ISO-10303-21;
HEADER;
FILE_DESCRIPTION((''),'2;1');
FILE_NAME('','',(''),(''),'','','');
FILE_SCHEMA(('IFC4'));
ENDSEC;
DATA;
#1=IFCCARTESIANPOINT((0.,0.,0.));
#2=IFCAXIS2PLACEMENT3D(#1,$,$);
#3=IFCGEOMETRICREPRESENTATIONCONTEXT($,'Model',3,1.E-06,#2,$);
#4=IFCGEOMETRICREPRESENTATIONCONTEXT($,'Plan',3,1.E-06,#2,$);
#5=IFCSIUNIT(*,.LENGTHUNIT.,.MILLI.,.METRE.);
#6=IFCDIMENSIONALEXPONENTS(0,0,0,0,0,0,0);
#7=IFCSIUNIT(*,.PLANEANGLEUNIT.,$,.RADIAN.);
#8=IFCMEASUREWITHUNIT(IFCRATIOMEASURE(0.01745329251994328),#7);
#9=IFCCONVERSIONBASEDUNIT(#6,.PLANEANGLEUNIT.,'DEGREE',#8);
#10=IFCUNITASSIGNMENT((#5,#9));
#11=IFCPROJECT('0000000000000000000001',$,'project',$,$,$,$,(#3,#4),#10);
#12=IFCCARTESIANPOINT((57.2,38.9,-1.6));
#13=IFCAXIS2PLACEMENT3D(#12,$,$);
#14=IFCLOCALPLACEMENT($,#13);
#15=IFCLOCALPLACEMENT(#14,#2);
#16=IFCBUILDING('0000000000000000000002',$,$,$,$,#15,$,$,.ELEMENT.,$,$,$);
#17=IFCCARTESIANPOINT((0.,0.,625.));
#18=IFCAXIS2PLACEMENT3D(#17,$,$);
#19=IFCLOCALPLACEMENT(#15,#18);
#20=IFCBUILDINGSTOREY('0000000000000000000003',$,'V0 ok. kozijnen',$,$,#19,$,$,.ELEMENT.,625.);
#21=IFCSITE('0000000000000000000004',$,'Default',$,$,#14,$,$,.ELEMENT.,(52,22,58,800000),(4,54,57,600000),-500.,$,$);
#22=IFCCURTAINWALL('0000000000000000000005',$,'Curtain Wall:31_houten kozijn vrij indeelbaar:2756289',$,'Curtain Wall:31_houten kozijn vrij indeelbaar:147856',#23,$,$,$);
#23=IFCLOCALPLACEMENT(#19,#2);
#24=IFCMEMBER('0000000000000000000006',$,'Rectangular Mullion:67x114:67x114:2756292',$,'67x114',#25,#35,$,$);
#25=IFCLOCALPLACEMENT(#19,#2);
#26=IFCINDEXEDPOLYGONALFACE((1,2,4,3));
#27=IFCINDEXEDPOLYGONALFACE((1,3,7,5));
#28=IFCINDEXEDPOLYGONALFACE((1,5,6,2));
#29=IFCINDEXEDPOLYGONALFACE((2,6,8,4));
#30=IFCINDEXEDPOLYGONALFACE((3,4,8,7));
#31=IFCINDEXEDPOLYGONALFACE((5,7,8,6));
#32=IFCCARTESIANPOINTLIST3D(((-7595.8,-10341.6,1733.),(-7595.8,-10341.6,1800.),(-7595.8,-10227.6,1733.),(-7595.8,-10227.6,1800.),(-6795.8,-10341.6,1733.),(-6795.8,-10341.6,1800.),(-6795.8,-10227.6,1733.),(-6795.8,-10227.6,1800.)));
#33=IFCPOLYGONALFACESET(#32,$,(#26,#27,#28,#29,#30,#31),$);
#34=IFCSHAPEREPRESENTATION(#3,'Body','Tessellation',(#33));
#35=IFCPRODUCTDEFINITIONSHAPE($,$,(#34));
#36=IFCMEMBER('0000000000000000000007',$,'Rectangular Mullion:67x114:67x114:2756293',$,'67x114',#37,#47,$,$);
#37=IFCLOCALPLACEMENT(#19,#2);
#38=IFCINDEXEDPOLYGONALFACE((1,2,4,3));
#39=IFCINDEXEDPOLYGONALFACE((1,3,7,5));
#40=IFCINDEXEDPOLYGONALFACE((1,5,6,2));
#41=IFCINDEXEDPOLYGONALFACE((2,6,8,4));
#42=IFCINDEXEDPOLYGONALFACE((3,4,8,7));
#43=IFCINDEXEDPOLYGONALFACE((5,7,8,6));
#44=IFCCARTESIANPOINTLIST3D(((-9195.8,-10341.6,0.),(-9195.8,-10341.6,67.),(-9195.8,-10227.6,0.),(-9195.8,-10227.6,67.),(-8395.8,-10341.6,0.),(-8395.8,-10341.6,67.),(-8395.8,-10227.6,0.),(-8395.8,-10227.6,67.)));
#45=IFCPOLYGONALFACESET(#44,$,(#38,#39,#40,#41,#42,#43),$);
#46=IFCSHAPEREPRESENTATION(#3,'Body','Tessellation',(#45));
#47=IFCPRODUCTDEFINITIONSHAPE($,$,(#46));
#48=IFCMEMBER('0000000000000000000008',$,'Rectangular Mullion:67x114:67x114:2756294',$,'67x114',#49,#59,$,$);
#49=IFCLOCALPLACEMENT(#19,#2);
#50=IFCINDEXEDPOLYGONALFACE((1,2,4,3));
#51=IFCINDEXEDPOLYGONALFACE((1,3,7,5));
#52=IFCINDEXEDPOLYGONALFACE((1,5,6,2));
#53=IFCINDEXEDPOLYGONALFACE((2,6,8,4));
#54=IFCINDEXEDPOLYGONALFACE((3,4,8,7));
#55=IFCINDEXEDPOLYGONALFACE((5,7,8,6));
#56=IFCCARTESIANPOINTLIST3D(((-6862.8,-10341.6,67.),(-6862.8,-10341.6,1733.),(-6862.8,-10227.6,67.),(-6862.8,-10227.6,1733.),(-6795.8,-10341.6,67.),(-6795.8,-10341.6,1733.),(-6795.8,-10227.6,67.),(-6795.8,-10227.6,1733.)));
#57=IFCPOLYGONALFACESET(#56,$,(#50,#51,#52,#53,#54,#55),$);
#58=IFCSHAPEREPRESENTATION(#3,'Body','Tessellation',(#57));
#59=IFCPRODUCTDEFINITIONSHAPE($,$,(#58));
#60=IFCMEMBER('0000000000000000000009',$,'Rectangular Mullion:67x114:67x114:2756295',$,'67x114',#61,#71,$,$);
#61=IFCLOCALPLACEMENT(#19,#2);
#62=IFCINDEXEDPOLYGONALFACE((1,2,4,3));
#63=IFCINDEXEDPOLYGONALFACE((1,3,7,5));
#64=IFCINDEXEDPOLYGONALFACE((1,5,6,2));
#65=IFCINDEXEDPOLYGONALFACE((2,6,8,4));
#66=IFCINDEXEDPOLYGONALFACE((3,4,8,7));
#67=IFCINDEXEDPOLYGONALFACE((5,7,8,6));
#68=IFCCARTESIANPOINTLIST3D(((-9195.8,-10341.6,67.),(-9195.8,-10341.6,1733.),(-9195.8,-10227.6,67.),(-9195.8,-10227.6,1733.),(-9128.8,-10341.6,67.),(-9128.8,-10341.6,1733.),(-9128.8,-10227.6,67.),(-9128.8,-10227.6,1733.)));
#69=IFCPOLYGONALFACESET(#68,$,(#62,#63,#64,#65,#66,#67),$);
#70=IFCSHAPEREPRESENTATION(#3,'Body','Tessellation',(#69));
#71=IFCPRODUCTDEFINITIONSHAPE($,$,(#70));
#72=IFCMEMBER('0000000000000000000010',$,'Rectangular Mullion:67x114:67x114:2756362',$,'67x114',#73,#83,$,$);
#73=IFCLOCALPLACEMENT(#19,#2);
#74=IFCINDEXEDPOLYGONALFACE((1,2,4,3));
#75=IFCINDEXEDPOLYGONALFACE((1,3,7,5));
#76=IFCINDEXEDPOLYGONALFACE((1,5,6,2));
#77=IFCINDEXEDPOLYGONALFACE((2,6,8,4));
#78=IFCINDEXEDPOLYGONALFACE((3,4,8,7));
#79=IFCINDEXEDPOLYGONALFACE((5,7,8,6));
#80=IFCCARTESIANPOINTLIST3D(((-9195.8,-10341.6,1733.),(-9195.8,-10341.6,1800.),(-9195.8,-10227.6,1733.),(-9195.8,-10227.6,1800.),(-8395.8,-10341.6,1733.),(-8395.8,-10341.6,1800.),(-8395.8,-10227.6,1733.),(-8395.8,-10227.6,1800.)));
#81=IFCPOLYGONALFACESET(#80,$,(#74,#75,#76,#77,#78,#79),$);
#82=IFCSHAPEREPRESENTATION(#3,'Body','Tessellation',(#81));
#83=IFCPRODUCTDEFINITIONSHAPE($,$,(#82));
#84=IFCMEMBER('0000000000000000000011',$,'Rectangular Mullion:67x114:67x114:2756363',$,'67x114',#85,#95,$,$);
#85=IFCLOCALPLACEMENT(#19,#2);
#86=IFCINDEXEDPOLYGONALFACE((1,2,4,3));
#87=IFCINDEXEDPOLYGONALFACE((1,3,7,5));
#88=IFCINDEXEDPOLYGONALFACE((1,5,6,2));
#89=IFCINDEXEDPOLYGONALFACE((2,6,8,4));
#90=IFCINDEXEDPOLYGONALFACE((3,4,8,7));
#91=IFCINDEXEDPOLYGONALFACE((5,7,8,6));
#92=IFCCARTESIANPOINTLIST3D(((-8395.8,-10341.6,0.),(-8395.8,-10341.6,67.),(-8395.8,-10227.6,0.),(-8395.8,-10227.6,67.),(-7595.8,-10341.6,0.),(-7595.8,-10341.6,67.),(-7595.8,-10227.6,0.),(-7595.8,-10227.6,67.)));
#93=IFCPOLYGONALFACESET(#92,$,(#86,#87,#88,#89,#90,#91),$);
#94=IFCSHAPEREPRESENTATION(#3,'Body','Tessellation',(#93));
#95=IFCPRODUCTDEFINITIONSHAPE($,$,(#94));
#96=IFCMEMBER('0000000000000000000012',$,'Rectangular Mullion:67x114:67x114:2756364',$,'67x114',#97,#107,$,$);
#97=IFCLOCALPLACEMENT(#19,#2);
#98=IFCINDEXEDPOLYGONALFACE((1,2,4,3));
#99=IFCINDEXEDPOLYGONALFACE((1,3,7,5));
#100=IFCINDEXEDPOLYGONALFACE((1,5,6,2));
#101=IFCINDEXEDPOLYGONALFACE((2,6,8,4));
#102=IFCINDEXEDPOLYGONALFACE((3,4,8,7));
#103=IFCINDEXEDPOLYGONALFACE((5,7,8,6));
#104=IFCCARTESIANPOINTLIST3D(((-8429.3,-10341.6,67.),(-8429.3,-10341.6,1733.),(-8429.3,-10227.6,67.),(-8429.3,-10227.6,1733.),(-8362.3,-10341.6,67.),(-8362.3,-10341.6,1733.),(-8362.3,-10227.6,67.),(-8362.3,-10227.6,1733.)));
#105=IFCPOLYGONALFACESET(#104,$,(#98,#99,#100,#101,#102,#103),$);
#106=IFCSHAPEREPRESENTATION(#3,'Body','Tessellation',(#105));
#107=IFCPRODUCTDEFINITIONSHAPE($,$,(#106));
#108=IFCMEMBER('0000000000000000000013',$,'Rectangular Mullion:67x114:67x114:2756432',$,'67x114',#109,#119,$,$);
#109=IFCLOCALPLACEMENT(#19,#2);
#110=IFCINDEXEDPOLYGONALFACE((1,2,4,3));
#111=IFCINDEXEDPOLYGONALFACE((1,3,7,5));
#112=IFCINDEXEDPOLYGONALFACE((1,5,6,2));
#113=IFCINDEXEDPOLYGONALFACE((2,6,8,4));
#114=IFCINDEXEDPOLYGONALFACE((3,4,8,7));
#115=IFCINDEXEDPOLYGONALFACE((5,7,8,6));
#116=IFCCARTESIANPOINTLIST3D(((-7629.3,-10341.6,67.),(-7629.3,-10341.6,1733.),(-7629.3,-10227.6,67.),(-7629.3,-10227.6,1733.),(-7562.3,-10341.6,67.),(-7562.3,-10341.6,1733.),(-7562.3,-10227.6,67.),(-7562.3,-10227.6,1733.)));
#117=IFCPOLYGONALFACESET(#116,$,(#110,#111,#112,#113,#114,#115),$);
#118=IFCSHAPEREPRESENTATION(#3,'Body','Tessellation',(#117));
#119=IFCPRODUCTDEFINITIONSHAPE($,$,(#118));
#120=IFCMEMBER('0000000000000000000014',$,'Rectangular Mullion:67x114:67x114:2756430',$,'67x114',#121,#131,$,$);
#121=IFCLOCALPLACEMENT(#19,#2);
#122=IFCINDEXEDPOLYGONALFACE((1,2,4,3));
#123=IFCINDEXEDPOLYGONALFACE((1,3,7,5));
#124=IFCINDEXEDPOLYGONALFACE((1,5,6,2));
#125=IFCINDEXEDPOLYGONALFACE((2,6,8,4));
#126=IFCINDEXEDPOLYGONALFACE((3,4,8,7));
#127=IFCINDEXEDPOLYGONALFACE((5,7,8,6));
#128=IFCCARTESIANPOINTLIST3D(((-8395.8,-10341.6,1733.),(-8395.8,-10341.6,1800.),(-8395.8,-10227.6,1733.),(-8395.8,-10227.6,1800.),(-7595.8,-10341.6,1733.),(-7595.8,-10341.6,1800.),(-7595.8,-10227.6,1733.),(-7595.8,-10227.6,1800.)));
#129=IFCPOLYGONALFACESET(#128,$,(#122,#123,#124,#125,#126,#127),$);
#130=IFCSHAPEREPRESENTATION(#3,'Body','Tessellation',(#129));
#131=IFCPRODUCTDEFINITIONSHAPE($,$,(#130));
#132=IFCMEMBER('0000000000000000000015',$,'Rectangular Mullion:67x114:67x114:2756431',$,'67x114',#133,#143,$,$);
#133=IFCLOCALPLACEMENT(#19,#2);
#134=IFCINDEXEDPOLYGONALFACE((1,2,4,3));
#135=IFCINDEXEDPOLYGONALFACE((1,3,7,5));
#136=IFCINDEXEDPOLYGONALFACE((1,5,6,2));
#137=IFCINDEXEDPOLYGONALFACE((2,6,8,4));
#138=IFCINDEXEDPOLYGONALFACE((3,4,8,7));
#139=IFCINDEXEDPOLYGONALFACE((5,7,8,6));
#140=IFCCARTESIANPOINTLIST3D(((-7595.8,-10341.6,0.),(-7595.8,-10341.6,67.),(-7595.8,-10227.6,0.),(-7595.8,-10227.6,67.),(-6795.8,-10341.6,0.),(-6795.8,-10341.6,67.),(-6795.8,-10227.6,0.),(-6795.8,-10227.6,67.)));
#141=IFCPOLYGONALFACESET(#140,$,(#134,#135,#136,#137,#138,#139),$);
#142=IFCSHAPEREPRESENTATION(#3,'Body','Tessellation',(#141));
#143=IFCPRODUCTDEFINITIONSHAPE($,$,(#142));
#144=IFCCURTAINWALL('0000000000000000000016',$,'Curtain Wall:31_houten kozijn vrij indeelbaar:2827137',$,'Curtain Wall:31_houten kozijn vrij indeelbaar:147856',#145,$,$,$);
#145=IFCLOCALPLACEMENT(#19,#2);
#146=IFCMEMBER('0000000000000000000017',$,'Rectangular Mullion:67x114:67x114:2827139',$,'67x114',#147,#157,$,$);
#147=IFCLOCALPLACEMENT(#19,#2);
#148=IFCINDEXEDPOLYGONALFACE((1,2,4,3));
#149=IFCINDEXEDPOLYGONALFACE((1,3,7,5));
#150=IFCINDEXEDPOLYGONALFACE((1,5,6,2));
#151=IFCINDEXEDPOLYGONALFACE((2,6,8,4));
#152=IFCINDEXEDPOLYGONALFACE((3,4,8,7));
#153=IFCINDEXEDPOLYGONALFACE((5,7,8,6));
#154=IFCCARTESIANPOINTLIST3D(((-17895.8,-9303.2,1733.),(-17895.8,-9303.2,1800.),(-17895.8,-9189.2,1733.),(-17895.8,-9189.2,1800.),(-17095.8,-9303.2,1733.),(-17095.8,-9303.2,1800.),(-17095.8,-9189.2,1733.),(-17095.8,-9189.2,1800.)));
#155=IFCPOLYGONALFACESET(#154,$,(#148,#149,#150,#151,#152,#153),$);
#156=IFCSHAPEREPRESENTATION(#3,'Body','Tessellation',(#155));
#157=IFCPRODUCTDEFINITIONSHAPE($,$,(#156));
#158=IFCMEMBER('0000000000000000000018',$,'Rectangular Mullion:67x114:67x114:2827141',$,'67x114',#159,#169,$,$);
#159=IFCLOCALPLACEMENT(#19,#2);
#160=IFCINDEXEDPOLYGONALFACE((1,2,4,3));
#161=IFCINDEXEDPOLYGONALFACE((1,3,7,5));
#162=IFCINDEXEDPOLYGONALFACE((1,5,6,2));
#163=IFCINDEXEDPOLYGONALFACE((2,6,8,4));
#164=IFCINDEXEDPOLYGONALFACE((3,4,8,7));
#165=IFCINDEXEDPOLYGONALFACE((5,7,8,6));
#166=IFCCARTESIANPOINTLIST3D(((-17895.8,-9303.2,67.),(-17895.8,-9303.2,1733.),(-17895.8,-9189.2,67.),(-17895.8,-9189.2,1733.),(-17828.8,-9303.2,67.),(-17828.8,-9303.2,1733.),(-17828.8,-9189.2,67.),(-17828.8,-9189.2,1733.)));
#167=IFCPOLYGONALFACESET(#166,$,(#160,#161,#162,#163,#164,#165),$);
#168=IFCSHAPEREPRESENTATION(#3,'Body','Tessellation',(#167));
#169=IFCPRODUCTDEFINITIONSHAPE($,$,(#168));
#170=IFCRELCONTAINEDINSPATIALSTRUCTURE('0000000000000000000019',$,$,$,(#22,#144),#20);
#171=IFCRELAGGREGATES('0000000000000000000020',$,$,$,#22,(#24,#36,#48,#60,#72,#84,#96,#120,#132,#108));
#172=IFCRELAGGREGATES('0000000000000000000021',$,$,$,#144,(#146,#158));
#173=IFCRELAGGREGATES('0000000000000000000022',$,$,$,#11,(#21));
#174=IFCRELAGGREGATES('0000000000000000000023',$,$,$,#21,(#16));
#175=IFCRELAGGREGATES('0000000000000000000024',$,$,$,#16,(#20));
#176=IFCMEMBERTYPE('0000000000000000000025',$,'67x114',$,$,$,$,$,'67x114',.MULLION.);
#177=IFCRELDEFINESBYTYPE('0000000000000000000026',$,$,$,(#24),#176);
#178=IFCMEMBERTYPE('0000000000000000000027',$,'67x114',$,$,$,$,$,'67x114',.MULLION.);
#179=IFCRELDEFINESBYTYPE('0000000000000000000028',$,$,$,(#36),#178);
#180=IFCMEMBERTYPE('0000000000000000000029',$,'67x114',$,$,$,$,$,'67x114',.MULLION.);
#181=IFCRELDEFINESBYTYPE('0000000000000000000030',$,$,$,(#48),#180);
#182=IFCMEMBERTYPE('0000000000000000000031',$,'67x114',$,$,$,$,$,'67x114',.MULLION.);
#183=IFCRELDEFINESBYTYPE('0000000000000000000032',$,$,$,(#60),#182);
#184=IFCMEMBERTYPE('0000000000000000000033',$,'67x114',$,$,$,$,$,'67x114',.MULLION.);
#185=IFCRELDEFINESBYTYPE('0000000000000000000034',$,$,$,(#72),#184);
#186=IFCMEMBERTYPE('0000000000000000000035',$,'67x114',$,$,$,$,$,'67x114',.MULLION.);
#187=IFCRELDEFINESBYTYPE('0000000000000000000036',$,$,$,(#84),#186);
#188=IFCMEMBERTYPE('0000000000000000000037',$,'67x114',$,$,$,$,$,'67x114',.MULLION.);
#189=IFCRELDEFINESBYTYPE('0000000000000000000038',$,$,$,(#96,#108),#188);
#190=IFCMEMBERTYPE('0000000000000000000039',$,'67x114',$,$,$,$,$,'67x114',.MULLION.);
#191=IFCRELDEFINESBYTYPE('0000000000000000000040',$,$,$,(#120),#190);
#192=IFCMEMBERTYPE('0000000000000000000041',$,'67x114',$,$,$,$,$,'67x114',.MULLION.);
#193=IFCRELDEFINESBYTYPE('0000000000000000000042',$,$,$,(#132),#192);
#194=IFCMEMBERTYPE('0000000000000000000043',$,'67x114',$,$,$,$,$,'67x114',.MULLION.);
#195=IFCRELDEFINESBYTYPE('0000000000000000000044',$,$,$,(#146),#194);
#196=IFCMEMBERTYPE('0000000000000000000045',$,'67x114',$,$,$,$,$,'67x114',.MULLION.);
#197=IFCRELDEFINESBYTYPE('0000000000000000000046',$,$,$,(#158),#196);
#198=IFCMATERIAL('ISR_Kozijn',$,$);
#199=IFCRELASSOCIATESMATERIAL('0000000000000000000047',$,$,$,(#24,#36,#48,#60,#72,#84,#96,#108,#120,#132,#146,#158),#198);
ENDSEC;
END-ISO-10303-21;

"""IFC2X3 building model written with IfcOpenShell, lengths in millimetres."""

from ifc_helpers import new_model, entity, si_unit, converted_unit, frame, origin, origin_2d_with_axis, place, context, project, spatial, rectangle, extrude, source, transform, mapped, material, type_object, type_shapes, element, aggregate, save


model = new_model("IFC2X3")

# Units and contexts
model_context = context("Model", 3, precision=1e-06, world=origin())
plan_context = context("Plan", 3, precision=1e-06, world=origin())
ifc_project = project(units=[si_unit("LENGTHUNIT", "METRE", prefix="MILLI"), converted_unit("PLANEANGLEUNIT", "DEGREE", entity("IfcRatioMeasure", 0.01745329251994328), si_unit("PLANEANGLEUNIT", "RADIAN"), dimensions=[0, 0, 0, 0, 0, 0, 0])], contexts=[model_context, plan_context])

# Site, building, storey
site_placement = place(None, frame((57.2, 38.9, -1.6)))
site = spatial("IfcSite", under=ifc_project, at=site_placement, Name="Default", CompositionType="ELEMENT", RefLatitude=(52, 22, 58, 800000), RefLongitude=(4, 54, 57, 600000), RefElevation=-500.0)
building_placement = place(site_placement, origin())
building = spatial("IfcBuilding", under=site, at=building_placement, CompositionType="ELEMENT")
storey_placement = place(building_placement, frame((0.0, 0.0, 625.0)))
storey = spatial("IfcBuildingStorey", under=building, at=storey_placement, Name="V0 ok. kozijnen", CompositionType="ELEMENT", Elevation=625.0)

# Curtain walls, members
curtain_wall_1_placement = place(storey_placement, origin())
curtain_wall_1 = element("IfcCurtainWall", 1, at=curtain_wall_1_placement, inside=storey, Name="Curtain Wall:31_houten kozijn vrij indeelbaar:2756289", ObjectType="Curtain Wall:31_houten kozijn vrij indeelbaar:147856")
ifc_material_1 = material(Name="ISR_Kozijn")
member_type_1 = type_object("IfcMemberType", Name="67x114", ElementType="67x114", PredefinedType="MULLION")
shared_shape_1 = source(origin(), model_context, "Body", "SweptSolid", [
    extrude(rectangle(XDim=67.0, YDim=114.0, at=origin_2d_with_axis()), frame((-33.5, 57.0, -800.0), z_axis=(0.0, 0.0, 1.0), x_axis=(-1.0, 0.0, 0.0)), (0.0, 0.0, 1.0), 800.0),
])
type_shapes(member_type_1, [shared_shape_1])
placement = place(building_placement, frame((0.0, 0.0, 2425.0)))
member_1_placement = place(placement, frame((-6795.8, -10227.6, 0.0), z_axis=(1.0, 0.0, 0.0), x_axis=(0.0, 0.0, 1.0)))
member_1 = element("IfcMember", 2, at=member_1_placement, type_object=member_type_1, material=ifc_material_1, Name="Rectangular Mullion:67x114:67x114:2756292", ObjectType="67x114", context=model_context, shape_type="MappedRepresentation", body=[
    mapped(shared_shape_1, transform((0.0, 0.0, 0.0), scale=1.0)),
])
member_type_2 = type_object("IfcMemberType", Name="67x114", ElementType="67x114", PredefinedType="MULLION")
shared_shape_2 = source(origin(), model_context, "Body", "SweptSolid", [
    extrude(rectangle(XDim=67.0, YDim=114.0, at=origin_2d_with_axis()), frame((-33.5, 57.0, -800.0), z_axis=(0.0, 0.0, 1.0), x_axis=(-1.0, 0.0, 0.0)), (0.0, 0.0, 1.0), 800.0),
])
type_shapes(member_type_2, [shared_shape_2])
member_2_placement = place(storey_placement, frame((-9195.8, -10227.6, 0.0), z_axis=(-1.0, 0.0, 0.0), x_axis=(0.0, 0.0, -1.0)))
member_2 = element("IfcMember", 3, at=member_2_placement, type_object=member_type_2, material=ifc_material_1, Name="Rectangular Mullion:67x114:67x114:2756293", ObjectType="67x114", context=model_context, shape_type="MappedRepresentation", body=[
    mapped(shared_shape_2, transform((0.0, 0.0, 0.0), scale=1.0)),
])
member_type_3 = type_object("IfcMemberType", Name="67x114", ElementType="67x114", PredefinedType="MULLION")
shared_shape_3 = source(origin(), model_context, "Body", "SweptSolid", [
    extrude(rectangle(XDim=67.0, YDim=114.0, at=origin_2d_with_axis()), frame((-33.5, 57.0, -1666.0), z_axis=(0.0, 0.0, 1.0), x_axis=(-1.0, 0.0, 0.0)), (0.0, 0.0, 1.0), 1666.0),
])
type_shapes(member_type_3, [shared_shape_3])
member_3_placement = place(storey_placement, frame((-6795.8, -10227.6, 67.0), z_axis=(0.0, 0.0, -1.0), x_axis=(1.0, 0.0, 0.0)))
member_3 = element("IfcMember", 4, at=member_3_placement, type_object=member_type_3, material=ifc_material_1, Name="Rectangular Mullion:67x114:67x114:2756294", ObjectType="67x114", context=model_context, shape_type="MappedRepresentation", body=[
    mapped(shared_shape_3, transform((0.0, 0.0, 0.0), scale=1.0)),
])
member_type_4 = type_object("IfcMemberType", Name="67x114", ElementType="67x114", PredefinedType="MULLION")
shared_shape_4 = source(origin(), model_context, "Body", "SweptSolid", [
    extrude(rectangle(XDim=67.0, YDim=114.0, at=origin_2d_with_axis()), frame((-33.5, 57.0, -1666.0), z_axis=(0.0, 0.0, 1.0), x_axis=(-1.0, 0.0, 0.0)), (0.0, 0.0, 1.0), 1666.0),
])
type_shapes(member_type_4, [shared_shape_4])
member_4_placement = place(storey_placement, frame((-9195.8, -10227.6, 1733.0), z_axis=(0.0, 0.0, 1.0), x_axis=(-1.0, 0.0, 0.0)))
member_4 = element("IfcMember", 5, at=member_4_placement, type_object=member_type_4, material=ifc_material_1, Name="Rectangular Mullion:67x114:67x114:2756295", ObjectType="67x114", context=model_context, shape_type="MappedRepresentation", body=[
    mapped(shared_shape_4, transform((0.0, 0.0, 0.0), scale=1.0)),
])
member_type_5 = type_object("IfcMemberType", Name="67x114", ElementType="67x114", PredefinedType="MULLION")
shared_shape_5 = source(origin(), model_context, "Body", "SweptSolid", [
    extrude(rectangle(XDim=67.0, YDim=114.0, at=origin_2d_with_axis()), frame((-33.5, 57.0, -800.0), z_axis=(0.0, 0.0, 1.0), x_axis=(-1.0, 0.0, 0.0)), (0.0, 0.0, 1.0), 800.0),
])
type_shapes(member_type_5, [shared_shape_5])
member_5_placement = place(placement, frame((-8395.8, -10227.6, 0.0), z_axis=(1.0, 0.0, 0.0), x_axis=(0.0, 0.0, 1.0)))
member_5 = element("IfcMember", 6, at=member_5_placement, type_object=member_type_5, material=ifc_material_1, Name="Rectangular Mullion:67x114:67x114:2756362", ObjectType="67x114", context=model_context, shape_type="MappedRepresentation", body=[
    mapped(shared_shape_5, transform((0.0, 0.0, 0.0), scale=1.0)),
])
member_type_6 = type_object("IfcMemberType", Name="67x114", ElementType="67x114", PredefinedType="MULLION")
shared_shape_6 = source(origin(), model_context, "Body", "SweptSolid", [
    extrude(rectangle(XDim=67.0, YDim=114.0, at=origin_2d_with_axis()), frame((-33.5, 57.0, -800.0), z_axis=(0.0, 0.0, 1.0), x_axis=(-1.0, 0.0, 0.0)), (0.0, 0.0, 1.0), 800.0),
])
type_shapes(member_type_6, [shared_shape_6])
member_6_placement = place(storey_placement, frame((-8395.8, -10227.6, 0.0), z_axis=(-1.0, 0.0, 0.0), x_axis=(0.0, 0.0, -1.0)))
member_6 = element("IfcMember", 7, at=member_6_placement, type_object=member_type_6, material=ifc_material_1, Name="Rectangular Mullion:67x114:67x114:2756363", ObjectType="67x114", context=model_context, shape_type="MappedRepresentation", body=[
    mapped(shared_shape_6, transform((0.0, 0.0, 0.0), scale=1.0)),
])
member_type_7 = type_object("IfcMemberType", Name="67x114", ElementType="67x114", PredefinedType="MULLION")
shared_shape_7 = source(origin(), model_context, "Body", "SweptSolid", [
    extrude(rectangle(XDim=67.0, YDim=114.0, at=origin_2d_with_axis()), frame((0.0, 57.0, -1666.0), z_axis=(0.0, 0.0, 1.0), x_axis=(-1.0, 0.0, 0.0)), (0.0, 0.0, 1.0), 1666.0),
])
type_shapes(member_type_7, [shared_shape_7])
member_7_placement = place(storey_placement, frame((-8395.8, -10227.6, 67.0), z_axis=(0.0, 0.0, -1.0), x_axis=(1.0, 0.0, 0.0)))
member_7 = element("IfcMember", 8, at=member_7_placement, type_object=member_type_7, material=ifc_material_1, Name="Rectangular Mullion:67x114:67x114:2756364", ObjectType="67x114", context=model_context, shape_type="MappedRepresentation", body=[
    mapped(shared_shape_7, transform((0.0, 0.0, 0.0), scale=1.0)),
])
member_8_placement = place(storey_placement, frame((-7595.8, -10227.6, 67.0), z_axis=(0.0, 0.0, -1.0), x_axis=(1.0, 0.0, 0.0)))
member_8 = element("IfcMember", 9, at=member_8_placement, type_object=member_type_7, material=ifc_material_1, Name="Rectangular Mullion:67x114:67x114:2756432", ObjectType="67x114", context=model_context, shape_type="MappedRepresentation", body=[
    mapped(shared_shape_7, transform((0.0, 0.0, 0.0), scale=1.0)),
])
member_type_8 = type_object("IfcMemberType", Name="67x114", ElementType="67x114", PredefinedType="MULLION")
shared_shape_8 = source(origin(), model_context, "Body", "SweptSolid", [
    extrude(rectangle(XDim=67.0, YDim=114.0, at=origin_2d_with_axis()), frame((-33.5, 57.0, -800.0), z_axis=(0.0, 0.0, 1.0), x_axis=(-1.0, 0.0, 0.0)), (0.0, 0.0, 1.0), 800.0),
])
type_shapes(member_type_8, [shared_shape_8])
member_9_placement = place(placement, frame((-7595.8, -10227.6, 0.0), z_axis=(1.0, 0.0, 0.0), x_axis=(0.0, 0.0, 1.0)))
member_9 = element("IfcMember", 10, at=member_9_placement, type_object=member_type_8, material=ifc_material_1, Name="Rectangular Mullion:67x114:67x114:2756430", ObjectType="67x114", context=model_context, shape_type="MappedRepresentation", body=[
    mapped(shared_shape_8, transform((0.0, 0.0, 0.0), scale=1.0)),
])
member_type_9 = type_object("IfcMemberType", Name="67x114", ElementType="67x114", PredefinedType="MULLION")
shared_shape_9 = source(origin(), model_context, "Body", "SweptSolid", [
    extrude(rectangle(XDim=67.0, YDim=114.0, at=origin_2d_with_axis()), frame((-33.5, 57.0, -800.0), z_axis=(0.0, 0.0, 1.0), x_axis=(-1.0, 0.0, 0.0)), (0.0, 0.0, 1.0), 800.0),
])
type_shapes(member_type_9, [shared_shape_9])
member_10_placement = place(storey_placement, frame((-7595.8, -10227.6, 0.0), z_axis=(-1.0, 0.0, 0.0), x_axis=(0.0, 0.0, -1.0)))
member_10 = element("IfcMember", 11, at=member_10_placement, type_object=member_type_9, material=ifc_material_1, Name="Rectangular Mullion:67x114:67x114:2756431", ObjectType="67x114", context=model_context, shape_type="MappedRepresentation", body=[
    mapped(shared_shape_9, transform((0.0, 0.0, 0.0), scale=1.0)),
])
curtain_wall_2_placement = place(storey_placement, origin())
curtain_wall_2 = element("IfcCurtainWall", 12, at=curtain_wall_2_placement, inside=storey, Name="Curtain Wall:31_houten kozijn vrij indeelbaar:2827137", ObjectType="Curtain Wall:31_houten kozijn vrij indeelbaar:147856")
member_type_10 = type_object("IfcMemberType", Name="67x114", ElementType="67x114", PredefinedType="MULLION")
shared_shape_10 = source(origin(), model_context, "Body", "SweptSolid", [
    extrude(rectangle(XDim=67.0, YDim=114.0, at=origin_2d_with_axis()), frame((-33.5, -57.0, -800.0), z_axis=(0.0, 0.0, 1.0), x_axis=(-1.0, 0.0, 0.0)), (0.0, 0.0, 1.0), 800.0),
])
type_shapes(member_type_10, [shared_shape_10])
member_11_placement = place(placement, frame((-17895.8, -9189.2, 0.0), z_axis=(-1.0, 0.0, 0.0), x_axis=(0.0, 0.0, 1.0)))
member_11 = element("IfcMember", 13, at=member_11_placement, type_object=member_type_10, material=ifc_material_1, Name="Rectangular Mullion:67x114:67x114:2827139", ObjectType="67x114", context=model_context, shape_type="MappedRepresentation", body=[
    mapped(shared_shape_10, transform((0.0, 0.0, 0.0), scale=1.0)),
])
member_type_11 = type_object("IfcMemberType", Name="67x114", ElementType="67x114", PredefinedType="MULLION")
shared_shape_11 = source(origin(), model_context, "Body", "SweptSolid", [
    extrude(rectangle(XDim=67.0, YDim=114.0, at=origin_2d_with_axis()), frame((-33.5, -57.0, -1666.0), z_axis=(0.0, 0.0, 1.0), x_axis=(-1.0, 0.0, 0.0)), (0.0, 0.0, 1.0), 1666.0),
])
type_shapes(member_type_11, [shared_shape_11])
member_12_placement = place(storey_placement, frame((-17895.8, -9189.2, 67.0), z_axis=(0.0, 0.0, -1.0), x_axis=(-1.0, 0.0, 0.0)))
member_12 = element("IfcMember", 14, at=member_12_placement, type_object=member_type_11, material=ifc_material_1, Name="Rectangular Mullion:67x114:67x114:2827141", ObjectType="67x114", context=model_context, shape_type="MappedRepresentation", body=[
    mapped(shared_shape_11, transform((0.0, 0.0, 0.0), scale=1.0)),
])

aggregate(curtain_wall_1, [member_1, member_2, member_3, member_4, member_5, member_6, member_7, member_9, member_10, member_8])
aggregate(curtain_wall_2, [member_11, member_12])

save(model, "model.ifc")
